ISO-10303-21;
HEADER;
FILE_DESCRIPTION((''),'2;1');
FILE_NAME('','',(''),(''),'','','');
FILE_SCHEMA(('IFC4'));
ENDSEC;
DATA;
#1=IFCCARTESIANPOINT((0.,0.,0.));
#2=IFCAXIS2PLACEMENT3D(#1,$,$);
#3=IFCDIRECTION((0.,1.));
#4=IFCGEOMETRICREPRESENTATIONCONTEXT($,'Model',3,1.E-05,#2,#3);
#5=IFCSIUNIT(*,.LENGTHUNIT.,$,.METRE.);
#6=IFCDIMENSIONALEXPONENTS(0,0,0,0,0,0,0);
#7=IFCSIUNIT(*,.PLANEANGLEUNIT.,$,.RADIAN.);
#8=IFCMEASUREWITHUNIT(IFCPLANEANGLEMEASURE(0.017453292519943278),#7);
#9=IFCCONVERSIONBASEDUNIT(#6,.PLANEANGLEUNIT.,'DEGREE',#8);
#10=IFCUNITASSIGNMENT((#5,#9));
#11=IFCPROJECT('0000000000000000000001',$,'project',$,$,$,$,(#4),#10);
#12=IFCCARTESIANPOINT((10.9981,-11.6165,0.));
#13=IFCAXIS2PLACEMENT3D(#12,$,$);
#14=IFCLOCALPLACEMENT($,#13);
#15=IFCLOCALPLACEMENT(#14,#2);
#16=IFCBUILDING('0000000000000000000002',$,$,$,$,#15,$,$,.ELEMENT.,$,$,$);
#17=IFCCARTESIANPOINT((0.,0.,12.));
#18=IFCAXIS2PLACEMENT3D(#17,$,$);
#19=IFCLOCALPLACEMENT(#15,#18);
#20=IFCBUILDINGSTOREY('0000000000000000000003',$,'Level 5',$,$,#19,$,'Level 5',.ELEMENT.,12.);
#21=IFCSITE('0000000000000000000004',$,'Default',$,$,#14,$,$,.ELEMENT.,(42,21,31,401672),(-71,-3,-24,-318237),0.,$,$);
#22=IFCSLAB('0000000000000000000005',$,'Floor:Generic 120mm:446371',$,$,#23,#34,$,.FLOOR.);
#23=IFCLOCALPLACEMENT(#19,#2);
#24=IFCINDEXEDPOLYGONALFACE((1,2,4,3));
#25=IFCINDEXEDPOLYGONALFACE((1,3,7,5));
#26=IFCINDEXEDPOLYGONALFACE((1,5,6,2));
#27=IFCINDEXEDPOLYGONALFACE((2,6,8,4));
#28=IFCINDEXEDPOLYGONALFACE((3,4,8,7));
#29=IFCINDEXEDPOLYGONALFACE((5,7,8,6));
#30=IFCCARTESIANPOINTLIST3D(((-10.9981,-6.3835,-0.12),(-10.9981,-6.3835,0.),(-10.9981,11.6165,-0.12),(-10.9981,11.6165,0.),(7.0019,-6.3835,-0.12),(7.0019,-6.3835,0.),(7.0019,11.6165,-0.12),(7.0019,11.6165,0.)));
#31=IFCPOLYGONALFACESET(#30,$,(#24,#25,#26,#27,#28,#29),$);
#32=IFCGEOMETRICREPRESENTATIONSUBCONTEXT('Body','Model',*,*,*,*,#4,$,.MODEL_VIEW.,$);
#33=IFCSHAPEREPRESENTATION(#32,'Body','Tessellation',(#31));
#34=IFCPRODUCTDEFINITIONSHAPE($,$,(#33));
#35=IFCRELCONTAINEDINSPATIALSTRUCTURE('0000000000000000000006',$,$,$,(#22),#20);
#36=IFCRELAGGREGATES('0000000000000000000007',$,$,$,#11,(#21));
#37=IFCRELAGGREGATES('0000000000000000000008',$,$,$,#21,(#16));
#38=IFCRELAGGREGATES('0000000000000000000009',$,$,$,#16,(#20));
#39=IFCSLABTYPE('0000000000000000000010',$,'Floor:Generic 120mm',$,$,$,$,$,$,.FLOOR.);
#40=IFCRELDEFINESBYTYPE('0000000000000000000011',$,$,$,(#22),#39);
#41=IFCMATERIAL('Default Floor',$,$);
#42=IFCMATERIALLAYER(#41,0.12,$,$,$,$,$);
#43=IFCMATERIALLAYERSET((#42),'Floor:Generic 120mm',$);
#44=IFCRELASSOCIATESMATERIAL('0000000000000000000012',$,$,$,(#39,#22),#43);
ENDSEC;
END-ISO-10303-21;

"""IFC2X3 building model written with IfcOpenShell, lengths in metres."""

from ifc_helpers import new_model, entity, si_unit, converted_unit, direction, frame, origin, origin_2d_with_axis, place, context, subcontext, project, spatial, rectangle, extrude, material, layer, layer_set, layer_usage, type_object, element, save


model = new_model("IFC2X3")

# Units and contexts
model_context = context("Model", 3, precision=1e-05, world=origin(), true_north=direction((0.0, 1.0)))
body_context = subcontext(model_context, "Body", "Model", "MODEL_VIEW")
ifc_project = project(units=[si_unit("LENGTHUNIT", "METRE"), converted_unit("PLANEANGLEUNIT", "DEGREE", entity("IfcPlaneAngleMeasure", 0.017453292519943278), si_unit("PLANEANGLEUNIT", "RADIAN"), dimensions=[0, 0, 0, 0, 0, 0, 0])], contexts=[model_context])

# Site, building, storey
site_placement = place(None, frame((10.9981, -11.6165, 0.0)))
site = spatial("IfcSite", under=ifc_project, at=site_placement, Name="Default", CompositionType="ELEMENT", RefLatitude=(42, 21, 31, 401672), RefLongitude=(-71, -3, -24, -318237), RefElevation=0.0)
building_placement = place(site_placement, origin())
building = spatial("IfcBuilding", under=site, at=building_placement, CompositionType="ELEMENT")
storey_placement = place(building_placement, frame((0.0, 0.0, 12.0)))
storey = spatial("IfcBuildingStorey", under=building, at=storey_placement, Name="Level 5", LongName="Level 5", CompositionType="ELEMENT", Elevation=12.0)

# Slab
ifc_material_1 = material(Name="Default Floor")
ifc_layer = layer(ifc_material_1, 0.12)
ifc_layer_set = layer_set([ifc_layer], Name="Floor:Generic 120mm")
ifc_layer_usage = layer_usage(ifc_layer_set, "AXIS3", "POSITIVE", 0.0)
slab_type = type_object("IfcSlabType", Name="Floor:Generic 120mm", PredefinedType="FLOOR", material=ifc_layer_set)
slab_placement = place(storey_placement, origin())
element("IfcSlab", 1, at=slab_placement, inside=storey, type_object=slab_type, material=ifc_layer_usage, Name="Floor:Generic 120mm:446371", PredefinedType="FLOOR", context=body_context, shape_type="SweptSolid", body=[
    extrude(rectangle(XDim=18.0, YDim=18.0, at=origin_2d_with_axis()), frame((-1.9981, 2.6165, 0.0), z_axis=(0.0, 0.0, -1.0), x_axis=(0.0, 1.0, 0.0)), (0.0, 0.0, 1.0), 0.12),
])

save(model, "model.ifc")
